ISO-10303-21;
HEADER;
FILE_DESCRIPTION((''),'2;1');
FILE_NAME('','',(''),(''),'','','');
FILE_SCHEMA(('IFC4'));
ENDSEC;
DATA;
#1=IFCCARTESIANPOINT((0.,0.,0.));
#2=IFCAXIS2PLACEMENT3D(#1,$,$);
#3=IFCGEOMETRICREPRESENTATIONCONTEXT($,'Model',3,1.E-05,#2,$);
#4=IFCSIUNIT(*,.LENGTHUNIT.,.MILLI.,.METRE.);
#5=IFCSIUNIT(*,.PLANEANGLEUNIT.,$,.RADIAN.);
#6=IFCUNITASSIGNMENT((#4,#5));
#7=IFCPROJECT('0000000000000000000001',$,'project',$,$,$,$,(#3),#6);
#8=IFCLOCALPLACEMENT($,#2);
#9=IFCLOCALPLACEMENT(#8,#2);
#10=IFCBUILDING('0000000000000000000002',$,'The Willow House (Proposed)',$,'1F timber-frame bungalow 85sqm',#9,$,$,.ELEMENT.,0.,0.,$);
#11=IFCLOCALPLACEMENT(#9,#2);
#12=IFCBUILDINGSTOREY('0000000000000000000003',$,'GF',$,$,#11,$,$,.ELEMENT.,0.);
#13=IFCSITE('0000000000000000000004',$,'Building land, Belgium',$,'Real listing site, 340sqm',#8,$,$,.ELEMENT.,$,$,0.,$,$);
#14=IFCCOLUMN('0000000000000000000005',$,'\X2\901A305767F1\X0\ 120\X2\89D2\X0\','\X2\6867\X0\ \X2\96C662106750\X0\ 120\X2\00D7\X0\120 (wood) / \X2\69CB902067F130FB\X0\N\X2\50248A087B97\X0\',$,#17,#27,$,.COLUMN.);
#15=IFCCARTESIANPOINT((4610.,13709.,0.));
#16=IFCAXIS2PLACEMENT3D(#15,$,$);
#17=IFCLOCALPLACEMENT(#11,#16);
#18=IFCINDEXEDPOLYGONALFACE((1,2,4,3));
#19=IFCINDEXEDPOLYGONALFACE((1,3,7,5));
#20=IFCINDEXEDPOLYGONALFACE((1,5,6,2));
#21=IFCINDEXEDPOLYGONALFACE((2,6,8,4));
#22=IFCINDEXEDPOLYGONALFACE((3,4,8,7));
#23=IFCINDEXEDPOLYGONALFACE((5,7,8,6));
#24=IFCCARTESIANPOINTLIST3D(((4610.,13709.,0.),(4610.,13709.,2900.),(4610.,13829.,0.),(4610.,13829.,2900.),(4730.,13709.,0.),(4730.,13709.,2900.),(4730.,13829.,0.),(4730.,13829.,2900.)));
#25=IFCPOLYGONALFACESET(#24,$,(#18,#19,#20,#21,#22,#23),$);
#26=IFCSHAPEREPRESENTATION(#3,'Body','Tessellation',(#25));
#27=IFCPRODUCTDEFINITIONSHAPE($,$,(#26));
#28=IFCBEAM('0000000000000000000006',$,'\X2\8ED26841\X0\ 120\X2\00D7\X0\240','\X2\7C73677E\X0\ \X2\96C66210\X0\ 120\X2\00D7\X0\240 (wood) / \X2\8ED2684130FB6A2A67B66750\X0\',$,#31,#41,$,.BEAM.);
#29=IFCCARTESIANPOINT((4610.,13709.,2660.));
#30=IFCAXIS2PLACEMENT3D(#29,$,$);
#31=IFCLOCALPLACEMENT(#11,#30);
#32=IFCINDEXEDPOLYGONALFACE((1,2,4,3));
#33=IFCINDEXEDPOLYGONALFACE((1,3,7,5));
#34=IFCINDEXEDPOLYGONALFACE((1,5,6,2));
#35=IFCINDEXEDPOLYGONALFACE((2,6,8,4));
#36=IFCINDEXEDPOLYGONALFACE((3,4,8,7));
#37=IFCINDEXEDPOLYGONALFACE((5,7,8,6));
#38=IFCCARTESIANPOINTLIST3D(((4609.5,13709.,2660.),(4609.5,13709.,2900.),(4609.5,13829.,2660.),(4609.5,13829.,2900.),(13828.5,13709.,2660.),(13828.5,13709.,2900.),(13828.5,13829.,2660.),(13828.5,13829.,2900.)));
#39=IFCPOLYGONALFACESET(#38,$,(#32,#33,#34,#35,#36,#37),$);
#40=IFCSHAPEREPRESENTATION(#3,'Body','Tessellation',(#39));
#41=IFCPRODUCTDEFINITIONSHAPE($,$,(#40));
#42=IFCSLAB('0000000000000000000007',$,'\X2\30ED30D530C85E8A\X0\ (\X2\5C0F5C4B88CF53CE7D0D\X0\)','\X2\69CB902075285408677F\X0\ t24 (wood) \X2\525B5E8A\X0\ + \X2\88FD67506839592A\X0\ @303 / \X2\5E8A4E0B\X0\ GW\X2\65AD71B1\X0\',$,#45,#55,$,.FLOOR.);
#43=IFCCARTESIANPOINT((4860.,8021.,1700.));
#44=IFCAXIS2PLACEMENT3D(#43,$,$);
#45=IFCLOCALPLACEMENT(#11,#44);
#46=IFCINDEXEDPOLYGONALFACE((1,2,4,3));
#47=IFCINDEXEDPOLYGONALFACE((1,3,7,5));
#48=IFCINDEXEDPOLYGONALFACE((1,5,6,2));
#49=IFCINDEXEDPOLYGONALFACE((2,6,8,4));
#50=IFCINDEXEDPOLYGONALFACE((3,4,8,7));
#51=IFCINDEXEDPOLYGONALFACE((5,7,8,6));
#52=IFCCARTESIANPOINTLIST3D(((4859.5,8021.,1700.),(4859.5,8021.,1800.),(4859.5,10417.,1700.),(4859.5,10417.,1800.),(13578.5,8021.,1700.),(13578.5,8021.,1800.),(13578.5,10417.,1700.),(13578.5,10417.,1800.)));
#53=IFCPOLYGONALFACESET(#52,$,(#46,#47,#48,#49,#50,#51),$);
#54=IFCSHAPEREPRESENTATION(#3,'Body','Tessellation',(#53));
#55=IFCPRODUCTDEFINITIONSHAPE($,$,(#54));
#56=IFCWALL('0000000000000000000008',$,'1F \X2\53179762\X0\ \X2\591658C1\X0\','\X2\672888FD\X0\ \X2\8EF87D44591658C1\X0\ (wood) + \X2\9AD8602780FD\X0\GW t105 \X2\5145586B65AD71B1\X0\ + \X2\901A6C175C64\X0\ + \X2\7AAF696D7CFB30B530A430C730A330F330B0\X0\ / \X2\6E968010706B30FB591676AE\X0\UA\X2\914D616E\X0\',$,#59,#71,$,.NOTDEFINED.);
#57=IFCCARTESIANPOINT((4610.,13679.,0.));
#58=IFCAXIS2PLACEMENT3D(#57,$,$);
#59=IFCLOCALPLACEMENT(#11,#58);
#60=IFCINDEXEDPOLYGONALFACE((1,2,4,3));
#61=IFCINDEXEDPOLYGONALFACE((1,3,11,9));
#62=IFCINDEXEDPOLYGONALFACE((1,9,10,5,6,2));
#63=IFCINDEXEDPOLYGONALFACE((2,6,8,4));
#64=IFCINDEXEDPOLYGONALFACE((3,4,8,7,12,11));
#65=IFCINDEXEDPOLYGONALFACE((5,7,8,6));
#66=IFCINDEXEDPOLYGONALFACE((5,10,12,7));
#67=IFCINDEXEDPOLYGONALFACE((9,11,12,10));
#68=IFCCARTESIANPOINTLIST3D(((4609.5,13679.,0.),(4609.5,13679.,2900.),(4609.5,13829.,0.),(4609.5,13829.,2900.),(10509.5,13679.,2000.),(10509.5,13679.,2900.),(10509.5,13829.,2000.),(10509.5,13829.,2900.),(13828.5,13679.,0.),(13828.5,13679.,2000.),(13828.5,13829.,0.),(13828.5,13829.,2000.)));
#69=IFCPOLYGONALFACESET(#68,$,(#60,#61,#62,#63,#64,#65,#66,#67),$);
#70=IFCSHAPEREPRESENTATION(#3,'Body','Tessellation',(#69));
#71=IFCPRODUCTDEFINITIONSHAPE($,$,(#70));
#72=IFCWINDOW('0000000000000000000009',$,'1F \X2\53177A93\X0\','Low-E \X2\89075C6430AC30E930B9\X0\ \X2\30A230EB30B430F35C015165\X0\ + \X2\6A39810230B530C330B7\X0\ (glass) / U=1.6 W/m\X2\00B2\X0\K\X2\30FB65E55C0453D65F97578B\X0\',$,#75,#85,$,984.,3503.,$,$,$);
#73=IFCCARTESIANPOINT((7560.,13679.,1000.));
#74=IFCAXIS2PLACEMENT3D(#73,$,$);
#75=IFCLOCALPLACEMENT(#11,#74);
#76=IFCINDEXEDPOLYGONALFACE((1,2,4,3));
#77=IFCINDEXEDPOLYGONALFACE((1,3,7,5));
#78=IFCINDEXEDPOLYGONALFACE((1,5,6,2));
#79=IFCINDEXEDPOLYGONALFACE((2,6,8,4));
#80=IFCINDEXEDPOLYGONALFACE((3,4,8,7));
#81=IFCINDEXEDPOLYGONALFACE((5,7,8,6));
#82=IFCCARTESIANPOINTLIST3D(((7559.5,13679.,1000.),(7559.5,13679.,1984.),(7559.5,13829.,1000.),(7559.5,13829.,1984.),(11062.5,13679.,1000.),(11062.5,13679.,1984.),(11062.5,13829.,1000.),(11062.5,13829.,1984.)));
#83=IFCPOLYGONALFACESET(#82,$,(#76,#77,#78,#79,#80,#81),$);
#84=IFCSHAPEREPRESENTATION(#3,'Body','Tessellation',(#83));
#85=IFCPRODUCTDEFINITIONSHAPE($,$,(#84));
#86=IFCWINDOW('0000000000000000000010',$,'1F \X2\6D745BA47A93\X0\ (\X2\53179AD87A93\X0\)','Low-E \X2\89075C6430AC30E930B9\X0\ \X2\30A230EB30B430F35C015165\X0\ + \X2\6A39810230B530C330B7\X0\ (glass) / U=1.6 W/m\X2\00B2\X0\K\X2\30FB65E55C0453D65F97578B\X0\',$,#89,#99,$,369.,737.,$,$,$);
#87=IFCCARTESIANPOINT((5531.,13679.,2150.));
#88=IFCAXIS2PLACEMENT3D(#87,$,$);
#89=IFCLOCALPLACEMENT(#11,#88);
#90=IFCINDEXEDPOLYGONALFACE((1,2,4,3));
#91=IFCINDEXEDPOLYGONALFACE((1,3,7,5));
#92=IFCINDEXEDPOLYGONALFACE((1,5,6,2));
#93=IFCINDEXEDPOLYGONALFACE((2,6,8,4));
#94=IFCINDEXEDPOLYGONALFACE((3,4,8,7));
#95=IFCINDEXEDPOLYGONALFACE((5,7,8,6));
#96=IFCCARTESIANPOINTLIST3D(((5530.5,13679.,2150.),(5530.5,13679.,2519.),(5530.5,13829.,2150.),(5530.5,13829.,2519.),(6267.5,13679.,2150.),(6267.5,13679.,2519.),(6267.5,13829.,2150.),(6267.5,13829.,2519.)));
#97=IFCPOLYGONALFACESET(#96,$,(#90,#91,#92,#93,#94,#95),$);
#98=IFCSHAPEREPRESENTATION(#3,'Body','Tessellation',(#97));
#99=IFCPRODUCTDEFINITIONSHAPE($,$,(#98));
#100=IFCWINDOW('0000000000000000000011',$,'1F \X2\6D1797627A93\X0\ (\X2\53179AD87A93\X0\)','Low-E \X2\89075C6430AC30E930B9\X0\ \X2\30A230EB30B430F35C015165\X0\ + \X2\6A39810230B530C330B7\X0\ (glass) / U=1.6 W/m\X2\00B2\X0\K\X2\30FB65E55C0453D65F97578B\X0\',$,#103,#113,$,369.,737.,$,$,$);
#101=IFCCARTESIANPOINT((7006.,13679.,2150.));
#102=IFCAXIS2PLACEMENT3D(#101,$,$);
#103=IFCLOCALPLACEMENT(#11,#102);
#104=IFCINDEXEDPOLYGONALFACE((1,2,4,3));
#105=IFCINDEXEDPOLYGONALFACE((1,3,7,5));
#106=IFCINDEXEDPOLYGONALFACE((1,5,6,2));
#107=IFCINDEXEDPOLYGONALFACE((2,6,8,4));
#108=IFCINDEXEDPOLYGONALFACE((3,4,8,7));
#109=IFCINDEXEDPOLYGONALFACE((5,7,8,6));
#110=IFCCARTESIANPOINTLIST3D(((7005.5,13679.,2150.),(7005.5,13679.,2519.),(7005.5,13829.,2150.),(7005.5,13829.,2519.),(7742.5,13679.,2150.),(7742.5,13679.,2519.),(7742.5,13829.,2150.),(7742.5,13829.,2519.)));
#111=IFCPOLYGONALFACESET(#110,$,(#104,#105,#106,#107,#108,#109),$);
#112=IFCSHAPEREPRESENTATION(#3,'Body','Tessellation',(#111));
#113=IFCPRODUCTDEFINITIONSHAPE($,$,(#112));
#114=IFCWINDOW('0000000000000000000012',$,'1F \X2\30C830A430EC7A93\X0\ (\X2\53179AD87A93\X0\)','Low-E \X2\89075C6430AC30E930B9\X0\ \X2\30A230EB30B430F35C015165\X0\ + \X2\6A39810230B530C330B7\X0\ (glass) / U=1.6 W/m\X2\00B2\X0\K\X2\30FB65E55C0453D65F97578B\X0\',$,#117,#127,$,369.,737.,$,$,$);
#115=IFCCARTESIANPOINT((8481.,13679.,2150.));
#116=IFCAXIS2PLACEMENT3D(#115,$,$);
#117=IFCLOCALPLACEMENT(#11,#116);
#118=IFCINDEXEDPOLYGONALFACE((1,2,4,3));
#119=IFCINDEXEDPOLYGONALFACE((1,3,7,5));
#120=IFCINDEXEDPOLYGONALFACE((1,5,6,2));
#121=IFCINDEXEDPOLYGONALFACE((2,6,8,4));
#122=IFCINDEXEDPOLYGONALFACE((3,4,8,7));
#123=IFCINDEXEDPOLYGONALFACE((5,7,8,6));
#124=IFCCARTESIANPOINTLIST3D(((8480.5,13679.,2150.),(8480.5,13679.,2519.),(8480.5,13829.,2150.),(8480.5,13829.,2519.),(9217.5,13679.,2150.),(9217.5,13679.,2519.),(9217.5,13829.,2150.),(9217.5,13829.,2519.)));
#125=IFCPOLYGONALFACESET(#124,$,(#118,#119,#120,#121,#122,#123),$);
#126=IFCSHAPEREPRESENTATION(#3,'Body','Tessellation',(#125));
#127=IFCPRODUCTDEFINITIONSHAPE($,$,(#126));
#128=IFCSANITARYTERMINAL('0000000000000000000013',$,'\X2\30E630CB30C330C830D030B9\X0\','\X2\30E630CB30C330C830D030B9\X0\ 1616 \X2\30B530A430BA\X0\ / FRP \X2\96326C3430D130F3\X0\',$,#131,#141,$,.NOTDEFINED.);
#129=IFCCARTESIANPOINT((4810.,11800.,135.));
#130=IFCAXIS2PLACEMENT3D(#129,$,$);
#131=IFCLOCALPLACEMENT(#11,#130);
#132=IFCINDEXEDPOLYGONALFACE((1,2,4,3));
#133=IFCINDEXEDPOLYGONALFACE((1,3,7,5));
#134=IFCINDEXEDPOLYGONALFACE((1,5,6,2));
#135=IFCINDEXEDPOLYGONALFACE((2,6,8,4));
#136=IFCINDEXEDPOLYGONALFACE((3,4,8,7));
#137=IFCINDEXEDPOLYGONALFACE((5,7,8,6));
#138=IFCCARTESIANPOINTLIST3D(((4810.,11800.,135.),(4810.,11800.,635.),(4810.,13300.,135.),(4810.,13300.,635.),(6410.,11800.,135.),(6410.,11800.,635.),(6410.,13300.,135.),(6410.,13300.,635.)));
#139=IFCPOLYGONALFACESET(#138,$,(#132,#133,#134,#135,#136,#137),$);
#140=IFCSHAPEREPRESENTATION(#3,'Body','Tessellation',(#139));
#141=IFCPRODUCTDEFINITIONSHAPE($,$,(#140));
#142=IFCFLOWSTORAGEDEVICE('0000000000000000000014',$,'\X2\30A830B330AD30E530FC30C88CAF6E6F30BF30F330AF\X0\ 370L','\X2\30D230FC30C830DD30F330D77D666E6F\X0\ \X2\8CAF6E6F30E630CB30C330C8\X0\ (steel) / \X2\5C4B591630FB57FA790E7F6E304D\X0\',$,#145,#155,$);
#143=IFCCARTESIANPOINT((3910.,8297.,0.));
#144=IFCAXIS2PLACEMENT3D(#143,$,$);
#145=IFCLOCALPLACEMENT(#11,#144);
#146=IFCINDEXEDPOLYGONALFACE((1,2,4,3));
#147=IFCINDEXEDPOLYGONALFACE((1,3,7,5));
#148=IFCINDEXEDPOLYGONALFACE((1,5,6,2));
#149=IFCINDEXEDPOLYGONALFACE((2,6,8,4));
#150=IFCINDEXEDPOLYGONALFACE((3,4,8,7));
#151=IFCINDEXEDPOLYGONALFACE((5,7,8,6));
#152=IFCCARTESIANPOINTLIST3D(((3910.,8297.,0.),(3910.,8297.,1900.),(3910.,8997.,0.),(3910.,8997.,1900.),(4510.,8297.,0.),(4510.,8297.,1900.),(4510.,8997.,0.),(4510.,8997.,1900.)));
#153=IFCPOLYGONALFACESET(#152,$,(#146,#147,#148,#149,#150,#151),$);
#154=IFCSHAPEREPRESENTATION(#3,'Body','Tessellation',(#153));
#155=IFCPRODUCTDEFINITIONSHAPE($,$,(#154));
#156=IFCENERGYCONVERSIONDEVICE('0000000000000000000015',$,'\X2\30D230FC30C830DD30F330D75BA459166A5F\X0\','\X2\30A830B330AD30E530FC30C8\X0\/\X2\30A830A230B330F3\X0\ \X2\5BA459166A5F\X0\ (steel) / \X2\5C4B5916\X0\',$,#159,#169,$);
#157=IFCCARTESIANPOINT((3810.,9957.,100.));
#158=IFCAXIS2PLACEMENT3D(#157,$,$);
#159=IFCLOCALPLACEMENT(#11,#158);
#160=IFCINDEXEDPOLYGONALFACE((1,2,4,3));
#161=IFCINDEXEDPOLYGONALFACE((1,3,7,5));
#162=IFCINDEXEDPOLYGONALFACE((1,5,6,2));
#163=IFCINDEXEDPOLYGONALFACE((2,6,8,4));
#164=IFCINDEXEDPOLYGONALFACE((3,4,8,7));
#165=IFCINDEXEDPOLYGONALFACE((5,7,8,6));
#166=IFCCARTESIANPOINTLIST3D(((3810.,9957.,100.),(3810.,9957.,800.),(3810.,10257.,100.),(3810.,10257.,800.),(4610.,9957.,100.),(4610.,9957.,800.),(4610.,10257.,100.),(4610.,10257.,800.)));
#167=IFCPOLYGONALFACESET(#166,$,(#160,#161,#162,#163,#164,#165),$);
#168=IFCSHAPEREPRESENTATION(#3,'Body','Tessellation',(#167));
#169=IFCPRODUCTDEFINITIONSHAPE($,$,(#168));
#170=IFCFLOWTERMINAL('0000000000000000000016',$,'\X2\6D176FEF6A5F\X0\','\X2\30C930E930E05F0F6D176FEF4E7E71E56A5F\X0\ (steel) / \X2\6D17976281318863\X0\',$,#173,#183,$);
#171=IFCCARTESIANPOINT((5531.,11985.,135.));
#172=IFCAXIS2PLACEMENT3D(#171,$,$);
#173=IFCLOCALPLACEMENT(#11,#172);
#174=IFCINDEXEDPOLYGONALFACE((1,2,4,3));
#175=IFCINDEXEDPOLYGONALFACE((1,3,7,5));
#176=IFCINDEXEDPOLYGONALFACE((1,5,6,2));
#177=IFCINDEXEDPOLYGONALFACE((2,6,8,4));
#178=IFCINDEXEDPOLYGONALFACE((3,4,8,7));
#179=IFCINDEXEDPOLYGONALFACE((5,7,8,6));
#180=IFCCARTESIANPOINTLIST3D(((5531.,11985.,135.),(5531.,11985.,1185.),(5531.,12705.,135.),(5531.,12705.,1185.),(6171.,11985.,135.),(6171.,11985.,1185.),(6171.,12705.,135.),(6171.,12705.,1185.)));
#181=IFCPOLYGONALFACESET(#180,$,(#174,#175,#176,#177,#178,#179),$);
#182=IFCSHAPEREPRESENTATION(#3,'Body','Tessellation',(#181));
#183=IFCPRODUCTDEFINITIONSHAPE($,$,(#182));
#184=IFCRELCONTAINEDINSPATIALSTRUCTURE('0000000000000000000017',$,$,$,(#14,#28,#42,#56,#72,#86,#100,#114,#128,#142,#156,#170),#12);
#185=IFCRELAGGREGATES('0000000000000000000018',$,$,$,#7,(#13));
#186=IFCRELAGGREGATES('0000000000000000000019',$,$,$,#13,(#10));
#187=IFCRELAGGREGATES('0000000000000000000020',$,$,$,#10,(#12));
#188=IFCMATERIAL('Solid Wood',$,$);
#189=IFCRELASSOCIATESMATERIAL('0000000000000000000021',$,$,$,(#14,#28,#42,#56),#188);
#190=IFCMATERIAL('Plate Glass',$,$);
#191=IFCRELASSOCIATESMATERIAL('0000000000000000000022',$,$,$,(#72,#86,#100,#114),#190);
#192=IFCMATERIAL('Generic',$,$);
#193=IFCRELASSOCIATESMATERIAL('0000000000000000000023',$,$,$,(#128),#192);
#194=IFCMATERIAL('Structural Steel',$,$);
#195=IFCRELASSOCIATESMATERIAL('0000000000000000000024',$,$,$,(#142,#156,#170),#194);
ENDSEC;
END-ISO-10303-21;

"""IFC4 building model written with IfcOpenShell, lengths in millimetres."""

from ifc_helpers import new_model, si_unit, frame, frame_2d, origin, place, context, project, spatial, rectangle, extrude, material, element, fill, save


model = new_model("IFC4")

# Units and contexts
model_context = context("Model", 3, precision=1e-05, world=origin())
ifc_project = project(units=[si_unit("LENGTHUNIT", "METRE", prefix="MILLI"), si_unit("PLANEANGLEUNIT", "RADIAN")], contexts=[model_context])

# Site, building, storey
site_placement = place(None, origin())
site = spatial("IfcSite", under=ifc_project, at=site_placement, Name="Building land, Belgium", ObjectType="Real listing site, 340sqm", CompositionType="ELEMENT", RefElevation=0.0)
building_placement = place(site_placement, origin())
building = spatial("IfcBuilding", under=site, at=building_placement, Name="The Willow House (Proposed)", ObjectType="1F timber-frame bungalow 85sqm", CompositionType="ELEMENT", ElevationOfRefHeight=0.0, ElevationOfTerrain=0.0)
storey_placement = place(building_placement, origin())
storey = spatial("IfcBuildingStorey", under=building, at=storey_placement, Name="GF", CompositionType="ELEMENT", Elevation=0.0)

# Column
ifc_material_1 = material(Name="Solid Wood")
column_1_placement = place(storey_placement, frame((4610.0, 13709.0, 0.0)))
element("IfcColumn", 1, at=column_1_placement, inside=storey, material=ifc_material_1, Name="通し柱 120角", Description="桧 集成材 120×120 (wood) / 構造柱・N値計算", PredefinedType="COLUMN", context=model_context, shape_type="SweptSolid", body=[
    extrude(rectangle(XDim=120.0, YDim=120.0, at=frame_2d((60.0, 60.0))), frame((4610.0, 13709.0, 0.0)), (0.0, 0.0, 1.0), 2900.0),
])

# Beam
beam_1_placement = place(storey_placement, frame((4610.0, 13709.0, 2660.0)))
element("IfcBeam", 2, at=beam_1_placement, inside=storey, material=ifc_material_1, Name="軒桁 120×240", Description="米松 集成 120×240 (wood) / 軒桁・横架材", PredefinedType="BEAM", context=model_context, shape_type="SweptSolid", body=[
    extrude(rectangle(XDim=9219.0, YDim=120.0, at=frame_2d((4609.0, 60.0))), frame((4610.0, 13709.0, 2660.0)), (0.0, 0.0, 1.0), 240.0),
])

# Slab
slab_placement = place(storey_placement, frame((4860.0, 8021.0, 1700.0)))
element("IfcSlab", 3, at=slab_placement, inside=storey, material=ifc_material_1, Name="ロフト床 (小屋裏収納)", Description="構造用合板 t24 (wood) 剛床 + 製材根太 @303 / 床下 GW断熱", PredefinedType="FLOOR", context=model_context, shape_type="SweptSolid", body=[
    extrude(rectangle(XDim=8719.0, YDim=2396.0, at=frame_2d((4359.0, 1198.0))), frame((4860.0, 8021.0, 1700.0)), (0.0, 0.0, 1.0), 100.0),
])

# Wall, openings, windows
wall_1_placement = place(storey_placement, frame((4610.0, 13679.0, 0.0)))
wall_1 = element("IfcWall", 4, at=wall_1_placement, inside=storey, material=ifc_material_1, Name="1F 北面 外壁", Description="木製 軸組外壁 (wood) + 高性能GW t105 充填断熱 + 通気層 + 窯業系サイディング / 準耐火・外皮UA配慮", PredefinedType="NOTDEFINED", context=model_context, shape_type="SweptSolid", body=[
    extrude(rectangle(XDim=9219.0, YDim=150.0, at=frame_2d((4609.0, 75.0))), frame((4610.0, 13679.0, 0.0)), (0.0, 0.0, 1.0), 2900.0),
])
opening_1_placement = place(storey_placement, frame((7560.0, 13679.0, 1000.0)))
opening_1 = element("IfcOpeningElement", 5, at=opening_1_placement, cuts=wall_1, PredefinedType="NOTDEFINED", context=model_context, shape_type="SweptSolid", body=[
    extrude(rectangle(XDim=3503.0, YDim=150.0, at=frame_2d((1751.0, 75.0))), frame((7560.0, 13679.0, 1000.0)), (0.0, 0.0, 1.0), 984.0),
])
opening_2_placement = place(storey_placement, frame((5531.0, 13679.0, 2150.0)))
opening_2 = element("IfcOpeningElement", 6, at=opening_2_placement, cuts=wall_1, PredefinedType="NOTDEFINED", context=model_context, shape_type="SweptSolid", body=[
    extrude(rectangle(XDim=737.0, YDim=150.0, at=frame_2d((368.0, 75.0))), frame((5531.0, 13679.0, 2150.0)), (0.0, 0.0, 1.0), 369.0),
])
opening_3_placement = place(storey_placement, frame((7006.0, 13679.0, 2150.0)))
opening_3 = element("IfcOpeningElement", 7, at=opening_3_placement, cuts=wall_1, PredefinedType="NOTDEFINED", context=model_context, shape_type="SweptSolid", body=[
    extrude(rectangle(XDim=737.0, YDim=150.0, at=frame_2d((368.0, 75.0))), frame((7006.0, 13679.0, 2150.0)), (0.0, 0.0, 1.0), 369.0),
])
opening_4_placement = place(storey_placement, frame((8481.0, 13679.0, 2150.0)))
opening_4 = element("IfcOpeningElement", 8, at=opening_4_placement, cuts=wall_1, PredefinedType="NOTDEFINED", context=model_context, shape_type="SweptSolid", body=[
    extrude(rectangle(XDim=737.0, YDim=150.0, at=frame_2d((368.0, 75.0))), frame((8481.0, 13679.0, 2150.0)), (0.0, 0.0, 1.0), 369.0),
])
ifc_material_2 = material(Name="Plate Glass")
window_1_placement = place(storey_placement, frame((7560.0, 13679.0, 1000.0)))
window_1 = element("IfcWindow", 9, at=window_1_placement, inside=storey, material=ifc_material_2, Name="1F 北窓", Description="Low-E 複層ガラス アルゴン封入 + 樹脂サッシ (glass) / U=1.6 W/m²K・日射取得型", OverallHeight=984.0, OverallWidth=3503.0, context=model_context, shape_type="SweptSolid", body=[
    extrude(rectangle(XDim=3503.0, YDim=150.0, at=frame_2d((1751.0, 75.0))), frame((7560.0, 13679.0, 1000.0)), (0.0, 0.0, 1.0), 984.0),
])
fill(opening_1, window_1)
window_2_placement = place(storey_placement, frame((5531.0, 13679.0, 2150.0)))
window_2 = element("IfcWindow", 10, at=window_2_placement, inside=storey, material=ifc_material_2, Name="1F 浴室窓 (北高窓)", Description="Low-E 複層ガラス アルゴン封入 + 樹脂サッシ (glass) / U=1.6 W/m²K・日射取得型", OverallHeight=369.0, OverallWidth=737.0, context=model_context, shape_type="SweptSolid", body=[
    extrude(rectangle(XDim=737.0, YDim=150.0, at=frame_2d((368.0, 75.0))), frame((5531.0, 13679.0, 2150.0)), (0.0, 0.0, 1.0), 369.0),
])
fill(opening_2, window_2)
window_3_placement = place(storey_placement, frame((7006.0, 13679.0, 2150.0)))
window_3 = element("IfcWindow", 11, at=window_3_placement, inside=storey, material=ifc_material_2, Name="1F 洗面窓 (北高窓)", Description="Low-E 複層ガラス アルゴン封入 + 樹脂サッシ (glass) / U=1.6 W/m²K・日射取得型", OverallHeight=369.0, OverallWidth=737.0, context=model_context, shape_type="SweptSolid", body=[
    extrude(rectangle(XDim=737.0, YDim=150.0, at=frame_2d((368.0, 75.0))), frame((7006.0, 13679.0, 2150.0)), (0.0, 0.0, 1.0), 369.0),
])
fill(opening_3, window_3)
window_4_placement = place(storey_placement, frame((8481.0, 13679.0, 2150.0)))
window_4 = element("IfcWindow", 12, at=window_4_placement, inside=storey, material=ifc_material_2, Name="1F トイレ窓 (北高窓)", Description="Low-E 複層ガラス アルゴン封入 + 樹脂サッシ (glass) / U=1.6 W/m²K・日射取得型", OverallHeight=369.0, OverallWidth=737.0, context=model_context, shape_type="SweptSolid", body=[
    extrude(rectangle(XDim=737.0, YDim=150.0, at=frame_2d((368.0, 75.0))), frame((8481.0, 13679.0, 2150.0)), (0.0, 0.0, 1.0), 369.0),
])
fill(opening_4, window_4)

# Shared definitions
ifc_material_3 = material(Name="Structural Steel")

# Sanitary terminal
ifc_material_4 = material(Name="Generic")
sanitary_terminal_placement = place(storey_placement, frame((4810.0, 11800.0, 135.0)))
element("IfcSanitaryTerminal", 13, at=sanitary_terminal_placement, inside=storey, material=ifc_material_4, Name="ユニットバス", Description="ユニットバス 1616 サイズ / FRP 防水パン", PredefinedType="NOTDEFINED", context=model_context, shape_type="SweptSolid", body=[
    extrude(rectangle(XDim=1600.0, YDim=1500.0, at=frame_2d((800.0, 750.0))), frame((4810.0, 11800.0, 135.0)), (0.0, 0.0, 1.0), 500.0),
])

# Flow storage device
flow_storage_device_placement = place(storey_placement, frame((3910.0, 8297.0, 0.0)))
element("IfcFlowStorageDevice", 14, at=flow_storage_device_placement, inside=storey, material=ifc_material_3, Name="エコキュート貯湯タンク 370L", Description="ヒートポンプ給湯 貯湯ユニット (steel) / 屋外・基礎置き", context=model_context, shape_type="SweptSolid", body=[
    extrude(rectangle(XDim=600.0, YDim=700.0, at=frame_2d((300.0, 350.0))), frame((3910.0, 8297.0, 0.0)), (0.0, 0.0, 1.0), 1900.0),
])

# Energy conversion device
energy_conversion_device_placement = place(storey_placement, frame((3810.0, 9957.0, 100.0)))
element("IfcEnergyConversionDevice", 15, at=energy_conversion_device_placement, inside=storey, material=ifc_material_3, Name="ヒートポンプ室外機", Description="エコキュート/エアコン 室外機 (steel) / 屋外", context=model_context, shape_type="SweptSolid", body=[
    extrude(rectangle(XDim=800.0, YDim=300.0, at=frame_2d((400.0, 150.0))), frame((3810.0, 9957.0, 100.0)), (0.0, 0.0, 1.0), 700.0),
])

# Flow terminal
flow_terminal_placement = place(storey_placement, frame((5531.0, 11985.0, 135.0)))
element("IfcFlowTerminal", 16, at=flow_terminal_placement, inside=storey, material=ifc_material_3, Name="洗濯機", Description="ドラム式洗濯乾燥機 (steel) / 洗面脱衣", context=model_context, shape_type="SweptSolid", body=[
    extrude(rectangle(XDim=640.0, YDim=720.0, at=frame_2d((320.0, 360.0))), frame((5531.0, 11985.0, 135.0)), (0.0, 0.0, 1.0), 1050.0),
])

save(model, "model.ifc")
